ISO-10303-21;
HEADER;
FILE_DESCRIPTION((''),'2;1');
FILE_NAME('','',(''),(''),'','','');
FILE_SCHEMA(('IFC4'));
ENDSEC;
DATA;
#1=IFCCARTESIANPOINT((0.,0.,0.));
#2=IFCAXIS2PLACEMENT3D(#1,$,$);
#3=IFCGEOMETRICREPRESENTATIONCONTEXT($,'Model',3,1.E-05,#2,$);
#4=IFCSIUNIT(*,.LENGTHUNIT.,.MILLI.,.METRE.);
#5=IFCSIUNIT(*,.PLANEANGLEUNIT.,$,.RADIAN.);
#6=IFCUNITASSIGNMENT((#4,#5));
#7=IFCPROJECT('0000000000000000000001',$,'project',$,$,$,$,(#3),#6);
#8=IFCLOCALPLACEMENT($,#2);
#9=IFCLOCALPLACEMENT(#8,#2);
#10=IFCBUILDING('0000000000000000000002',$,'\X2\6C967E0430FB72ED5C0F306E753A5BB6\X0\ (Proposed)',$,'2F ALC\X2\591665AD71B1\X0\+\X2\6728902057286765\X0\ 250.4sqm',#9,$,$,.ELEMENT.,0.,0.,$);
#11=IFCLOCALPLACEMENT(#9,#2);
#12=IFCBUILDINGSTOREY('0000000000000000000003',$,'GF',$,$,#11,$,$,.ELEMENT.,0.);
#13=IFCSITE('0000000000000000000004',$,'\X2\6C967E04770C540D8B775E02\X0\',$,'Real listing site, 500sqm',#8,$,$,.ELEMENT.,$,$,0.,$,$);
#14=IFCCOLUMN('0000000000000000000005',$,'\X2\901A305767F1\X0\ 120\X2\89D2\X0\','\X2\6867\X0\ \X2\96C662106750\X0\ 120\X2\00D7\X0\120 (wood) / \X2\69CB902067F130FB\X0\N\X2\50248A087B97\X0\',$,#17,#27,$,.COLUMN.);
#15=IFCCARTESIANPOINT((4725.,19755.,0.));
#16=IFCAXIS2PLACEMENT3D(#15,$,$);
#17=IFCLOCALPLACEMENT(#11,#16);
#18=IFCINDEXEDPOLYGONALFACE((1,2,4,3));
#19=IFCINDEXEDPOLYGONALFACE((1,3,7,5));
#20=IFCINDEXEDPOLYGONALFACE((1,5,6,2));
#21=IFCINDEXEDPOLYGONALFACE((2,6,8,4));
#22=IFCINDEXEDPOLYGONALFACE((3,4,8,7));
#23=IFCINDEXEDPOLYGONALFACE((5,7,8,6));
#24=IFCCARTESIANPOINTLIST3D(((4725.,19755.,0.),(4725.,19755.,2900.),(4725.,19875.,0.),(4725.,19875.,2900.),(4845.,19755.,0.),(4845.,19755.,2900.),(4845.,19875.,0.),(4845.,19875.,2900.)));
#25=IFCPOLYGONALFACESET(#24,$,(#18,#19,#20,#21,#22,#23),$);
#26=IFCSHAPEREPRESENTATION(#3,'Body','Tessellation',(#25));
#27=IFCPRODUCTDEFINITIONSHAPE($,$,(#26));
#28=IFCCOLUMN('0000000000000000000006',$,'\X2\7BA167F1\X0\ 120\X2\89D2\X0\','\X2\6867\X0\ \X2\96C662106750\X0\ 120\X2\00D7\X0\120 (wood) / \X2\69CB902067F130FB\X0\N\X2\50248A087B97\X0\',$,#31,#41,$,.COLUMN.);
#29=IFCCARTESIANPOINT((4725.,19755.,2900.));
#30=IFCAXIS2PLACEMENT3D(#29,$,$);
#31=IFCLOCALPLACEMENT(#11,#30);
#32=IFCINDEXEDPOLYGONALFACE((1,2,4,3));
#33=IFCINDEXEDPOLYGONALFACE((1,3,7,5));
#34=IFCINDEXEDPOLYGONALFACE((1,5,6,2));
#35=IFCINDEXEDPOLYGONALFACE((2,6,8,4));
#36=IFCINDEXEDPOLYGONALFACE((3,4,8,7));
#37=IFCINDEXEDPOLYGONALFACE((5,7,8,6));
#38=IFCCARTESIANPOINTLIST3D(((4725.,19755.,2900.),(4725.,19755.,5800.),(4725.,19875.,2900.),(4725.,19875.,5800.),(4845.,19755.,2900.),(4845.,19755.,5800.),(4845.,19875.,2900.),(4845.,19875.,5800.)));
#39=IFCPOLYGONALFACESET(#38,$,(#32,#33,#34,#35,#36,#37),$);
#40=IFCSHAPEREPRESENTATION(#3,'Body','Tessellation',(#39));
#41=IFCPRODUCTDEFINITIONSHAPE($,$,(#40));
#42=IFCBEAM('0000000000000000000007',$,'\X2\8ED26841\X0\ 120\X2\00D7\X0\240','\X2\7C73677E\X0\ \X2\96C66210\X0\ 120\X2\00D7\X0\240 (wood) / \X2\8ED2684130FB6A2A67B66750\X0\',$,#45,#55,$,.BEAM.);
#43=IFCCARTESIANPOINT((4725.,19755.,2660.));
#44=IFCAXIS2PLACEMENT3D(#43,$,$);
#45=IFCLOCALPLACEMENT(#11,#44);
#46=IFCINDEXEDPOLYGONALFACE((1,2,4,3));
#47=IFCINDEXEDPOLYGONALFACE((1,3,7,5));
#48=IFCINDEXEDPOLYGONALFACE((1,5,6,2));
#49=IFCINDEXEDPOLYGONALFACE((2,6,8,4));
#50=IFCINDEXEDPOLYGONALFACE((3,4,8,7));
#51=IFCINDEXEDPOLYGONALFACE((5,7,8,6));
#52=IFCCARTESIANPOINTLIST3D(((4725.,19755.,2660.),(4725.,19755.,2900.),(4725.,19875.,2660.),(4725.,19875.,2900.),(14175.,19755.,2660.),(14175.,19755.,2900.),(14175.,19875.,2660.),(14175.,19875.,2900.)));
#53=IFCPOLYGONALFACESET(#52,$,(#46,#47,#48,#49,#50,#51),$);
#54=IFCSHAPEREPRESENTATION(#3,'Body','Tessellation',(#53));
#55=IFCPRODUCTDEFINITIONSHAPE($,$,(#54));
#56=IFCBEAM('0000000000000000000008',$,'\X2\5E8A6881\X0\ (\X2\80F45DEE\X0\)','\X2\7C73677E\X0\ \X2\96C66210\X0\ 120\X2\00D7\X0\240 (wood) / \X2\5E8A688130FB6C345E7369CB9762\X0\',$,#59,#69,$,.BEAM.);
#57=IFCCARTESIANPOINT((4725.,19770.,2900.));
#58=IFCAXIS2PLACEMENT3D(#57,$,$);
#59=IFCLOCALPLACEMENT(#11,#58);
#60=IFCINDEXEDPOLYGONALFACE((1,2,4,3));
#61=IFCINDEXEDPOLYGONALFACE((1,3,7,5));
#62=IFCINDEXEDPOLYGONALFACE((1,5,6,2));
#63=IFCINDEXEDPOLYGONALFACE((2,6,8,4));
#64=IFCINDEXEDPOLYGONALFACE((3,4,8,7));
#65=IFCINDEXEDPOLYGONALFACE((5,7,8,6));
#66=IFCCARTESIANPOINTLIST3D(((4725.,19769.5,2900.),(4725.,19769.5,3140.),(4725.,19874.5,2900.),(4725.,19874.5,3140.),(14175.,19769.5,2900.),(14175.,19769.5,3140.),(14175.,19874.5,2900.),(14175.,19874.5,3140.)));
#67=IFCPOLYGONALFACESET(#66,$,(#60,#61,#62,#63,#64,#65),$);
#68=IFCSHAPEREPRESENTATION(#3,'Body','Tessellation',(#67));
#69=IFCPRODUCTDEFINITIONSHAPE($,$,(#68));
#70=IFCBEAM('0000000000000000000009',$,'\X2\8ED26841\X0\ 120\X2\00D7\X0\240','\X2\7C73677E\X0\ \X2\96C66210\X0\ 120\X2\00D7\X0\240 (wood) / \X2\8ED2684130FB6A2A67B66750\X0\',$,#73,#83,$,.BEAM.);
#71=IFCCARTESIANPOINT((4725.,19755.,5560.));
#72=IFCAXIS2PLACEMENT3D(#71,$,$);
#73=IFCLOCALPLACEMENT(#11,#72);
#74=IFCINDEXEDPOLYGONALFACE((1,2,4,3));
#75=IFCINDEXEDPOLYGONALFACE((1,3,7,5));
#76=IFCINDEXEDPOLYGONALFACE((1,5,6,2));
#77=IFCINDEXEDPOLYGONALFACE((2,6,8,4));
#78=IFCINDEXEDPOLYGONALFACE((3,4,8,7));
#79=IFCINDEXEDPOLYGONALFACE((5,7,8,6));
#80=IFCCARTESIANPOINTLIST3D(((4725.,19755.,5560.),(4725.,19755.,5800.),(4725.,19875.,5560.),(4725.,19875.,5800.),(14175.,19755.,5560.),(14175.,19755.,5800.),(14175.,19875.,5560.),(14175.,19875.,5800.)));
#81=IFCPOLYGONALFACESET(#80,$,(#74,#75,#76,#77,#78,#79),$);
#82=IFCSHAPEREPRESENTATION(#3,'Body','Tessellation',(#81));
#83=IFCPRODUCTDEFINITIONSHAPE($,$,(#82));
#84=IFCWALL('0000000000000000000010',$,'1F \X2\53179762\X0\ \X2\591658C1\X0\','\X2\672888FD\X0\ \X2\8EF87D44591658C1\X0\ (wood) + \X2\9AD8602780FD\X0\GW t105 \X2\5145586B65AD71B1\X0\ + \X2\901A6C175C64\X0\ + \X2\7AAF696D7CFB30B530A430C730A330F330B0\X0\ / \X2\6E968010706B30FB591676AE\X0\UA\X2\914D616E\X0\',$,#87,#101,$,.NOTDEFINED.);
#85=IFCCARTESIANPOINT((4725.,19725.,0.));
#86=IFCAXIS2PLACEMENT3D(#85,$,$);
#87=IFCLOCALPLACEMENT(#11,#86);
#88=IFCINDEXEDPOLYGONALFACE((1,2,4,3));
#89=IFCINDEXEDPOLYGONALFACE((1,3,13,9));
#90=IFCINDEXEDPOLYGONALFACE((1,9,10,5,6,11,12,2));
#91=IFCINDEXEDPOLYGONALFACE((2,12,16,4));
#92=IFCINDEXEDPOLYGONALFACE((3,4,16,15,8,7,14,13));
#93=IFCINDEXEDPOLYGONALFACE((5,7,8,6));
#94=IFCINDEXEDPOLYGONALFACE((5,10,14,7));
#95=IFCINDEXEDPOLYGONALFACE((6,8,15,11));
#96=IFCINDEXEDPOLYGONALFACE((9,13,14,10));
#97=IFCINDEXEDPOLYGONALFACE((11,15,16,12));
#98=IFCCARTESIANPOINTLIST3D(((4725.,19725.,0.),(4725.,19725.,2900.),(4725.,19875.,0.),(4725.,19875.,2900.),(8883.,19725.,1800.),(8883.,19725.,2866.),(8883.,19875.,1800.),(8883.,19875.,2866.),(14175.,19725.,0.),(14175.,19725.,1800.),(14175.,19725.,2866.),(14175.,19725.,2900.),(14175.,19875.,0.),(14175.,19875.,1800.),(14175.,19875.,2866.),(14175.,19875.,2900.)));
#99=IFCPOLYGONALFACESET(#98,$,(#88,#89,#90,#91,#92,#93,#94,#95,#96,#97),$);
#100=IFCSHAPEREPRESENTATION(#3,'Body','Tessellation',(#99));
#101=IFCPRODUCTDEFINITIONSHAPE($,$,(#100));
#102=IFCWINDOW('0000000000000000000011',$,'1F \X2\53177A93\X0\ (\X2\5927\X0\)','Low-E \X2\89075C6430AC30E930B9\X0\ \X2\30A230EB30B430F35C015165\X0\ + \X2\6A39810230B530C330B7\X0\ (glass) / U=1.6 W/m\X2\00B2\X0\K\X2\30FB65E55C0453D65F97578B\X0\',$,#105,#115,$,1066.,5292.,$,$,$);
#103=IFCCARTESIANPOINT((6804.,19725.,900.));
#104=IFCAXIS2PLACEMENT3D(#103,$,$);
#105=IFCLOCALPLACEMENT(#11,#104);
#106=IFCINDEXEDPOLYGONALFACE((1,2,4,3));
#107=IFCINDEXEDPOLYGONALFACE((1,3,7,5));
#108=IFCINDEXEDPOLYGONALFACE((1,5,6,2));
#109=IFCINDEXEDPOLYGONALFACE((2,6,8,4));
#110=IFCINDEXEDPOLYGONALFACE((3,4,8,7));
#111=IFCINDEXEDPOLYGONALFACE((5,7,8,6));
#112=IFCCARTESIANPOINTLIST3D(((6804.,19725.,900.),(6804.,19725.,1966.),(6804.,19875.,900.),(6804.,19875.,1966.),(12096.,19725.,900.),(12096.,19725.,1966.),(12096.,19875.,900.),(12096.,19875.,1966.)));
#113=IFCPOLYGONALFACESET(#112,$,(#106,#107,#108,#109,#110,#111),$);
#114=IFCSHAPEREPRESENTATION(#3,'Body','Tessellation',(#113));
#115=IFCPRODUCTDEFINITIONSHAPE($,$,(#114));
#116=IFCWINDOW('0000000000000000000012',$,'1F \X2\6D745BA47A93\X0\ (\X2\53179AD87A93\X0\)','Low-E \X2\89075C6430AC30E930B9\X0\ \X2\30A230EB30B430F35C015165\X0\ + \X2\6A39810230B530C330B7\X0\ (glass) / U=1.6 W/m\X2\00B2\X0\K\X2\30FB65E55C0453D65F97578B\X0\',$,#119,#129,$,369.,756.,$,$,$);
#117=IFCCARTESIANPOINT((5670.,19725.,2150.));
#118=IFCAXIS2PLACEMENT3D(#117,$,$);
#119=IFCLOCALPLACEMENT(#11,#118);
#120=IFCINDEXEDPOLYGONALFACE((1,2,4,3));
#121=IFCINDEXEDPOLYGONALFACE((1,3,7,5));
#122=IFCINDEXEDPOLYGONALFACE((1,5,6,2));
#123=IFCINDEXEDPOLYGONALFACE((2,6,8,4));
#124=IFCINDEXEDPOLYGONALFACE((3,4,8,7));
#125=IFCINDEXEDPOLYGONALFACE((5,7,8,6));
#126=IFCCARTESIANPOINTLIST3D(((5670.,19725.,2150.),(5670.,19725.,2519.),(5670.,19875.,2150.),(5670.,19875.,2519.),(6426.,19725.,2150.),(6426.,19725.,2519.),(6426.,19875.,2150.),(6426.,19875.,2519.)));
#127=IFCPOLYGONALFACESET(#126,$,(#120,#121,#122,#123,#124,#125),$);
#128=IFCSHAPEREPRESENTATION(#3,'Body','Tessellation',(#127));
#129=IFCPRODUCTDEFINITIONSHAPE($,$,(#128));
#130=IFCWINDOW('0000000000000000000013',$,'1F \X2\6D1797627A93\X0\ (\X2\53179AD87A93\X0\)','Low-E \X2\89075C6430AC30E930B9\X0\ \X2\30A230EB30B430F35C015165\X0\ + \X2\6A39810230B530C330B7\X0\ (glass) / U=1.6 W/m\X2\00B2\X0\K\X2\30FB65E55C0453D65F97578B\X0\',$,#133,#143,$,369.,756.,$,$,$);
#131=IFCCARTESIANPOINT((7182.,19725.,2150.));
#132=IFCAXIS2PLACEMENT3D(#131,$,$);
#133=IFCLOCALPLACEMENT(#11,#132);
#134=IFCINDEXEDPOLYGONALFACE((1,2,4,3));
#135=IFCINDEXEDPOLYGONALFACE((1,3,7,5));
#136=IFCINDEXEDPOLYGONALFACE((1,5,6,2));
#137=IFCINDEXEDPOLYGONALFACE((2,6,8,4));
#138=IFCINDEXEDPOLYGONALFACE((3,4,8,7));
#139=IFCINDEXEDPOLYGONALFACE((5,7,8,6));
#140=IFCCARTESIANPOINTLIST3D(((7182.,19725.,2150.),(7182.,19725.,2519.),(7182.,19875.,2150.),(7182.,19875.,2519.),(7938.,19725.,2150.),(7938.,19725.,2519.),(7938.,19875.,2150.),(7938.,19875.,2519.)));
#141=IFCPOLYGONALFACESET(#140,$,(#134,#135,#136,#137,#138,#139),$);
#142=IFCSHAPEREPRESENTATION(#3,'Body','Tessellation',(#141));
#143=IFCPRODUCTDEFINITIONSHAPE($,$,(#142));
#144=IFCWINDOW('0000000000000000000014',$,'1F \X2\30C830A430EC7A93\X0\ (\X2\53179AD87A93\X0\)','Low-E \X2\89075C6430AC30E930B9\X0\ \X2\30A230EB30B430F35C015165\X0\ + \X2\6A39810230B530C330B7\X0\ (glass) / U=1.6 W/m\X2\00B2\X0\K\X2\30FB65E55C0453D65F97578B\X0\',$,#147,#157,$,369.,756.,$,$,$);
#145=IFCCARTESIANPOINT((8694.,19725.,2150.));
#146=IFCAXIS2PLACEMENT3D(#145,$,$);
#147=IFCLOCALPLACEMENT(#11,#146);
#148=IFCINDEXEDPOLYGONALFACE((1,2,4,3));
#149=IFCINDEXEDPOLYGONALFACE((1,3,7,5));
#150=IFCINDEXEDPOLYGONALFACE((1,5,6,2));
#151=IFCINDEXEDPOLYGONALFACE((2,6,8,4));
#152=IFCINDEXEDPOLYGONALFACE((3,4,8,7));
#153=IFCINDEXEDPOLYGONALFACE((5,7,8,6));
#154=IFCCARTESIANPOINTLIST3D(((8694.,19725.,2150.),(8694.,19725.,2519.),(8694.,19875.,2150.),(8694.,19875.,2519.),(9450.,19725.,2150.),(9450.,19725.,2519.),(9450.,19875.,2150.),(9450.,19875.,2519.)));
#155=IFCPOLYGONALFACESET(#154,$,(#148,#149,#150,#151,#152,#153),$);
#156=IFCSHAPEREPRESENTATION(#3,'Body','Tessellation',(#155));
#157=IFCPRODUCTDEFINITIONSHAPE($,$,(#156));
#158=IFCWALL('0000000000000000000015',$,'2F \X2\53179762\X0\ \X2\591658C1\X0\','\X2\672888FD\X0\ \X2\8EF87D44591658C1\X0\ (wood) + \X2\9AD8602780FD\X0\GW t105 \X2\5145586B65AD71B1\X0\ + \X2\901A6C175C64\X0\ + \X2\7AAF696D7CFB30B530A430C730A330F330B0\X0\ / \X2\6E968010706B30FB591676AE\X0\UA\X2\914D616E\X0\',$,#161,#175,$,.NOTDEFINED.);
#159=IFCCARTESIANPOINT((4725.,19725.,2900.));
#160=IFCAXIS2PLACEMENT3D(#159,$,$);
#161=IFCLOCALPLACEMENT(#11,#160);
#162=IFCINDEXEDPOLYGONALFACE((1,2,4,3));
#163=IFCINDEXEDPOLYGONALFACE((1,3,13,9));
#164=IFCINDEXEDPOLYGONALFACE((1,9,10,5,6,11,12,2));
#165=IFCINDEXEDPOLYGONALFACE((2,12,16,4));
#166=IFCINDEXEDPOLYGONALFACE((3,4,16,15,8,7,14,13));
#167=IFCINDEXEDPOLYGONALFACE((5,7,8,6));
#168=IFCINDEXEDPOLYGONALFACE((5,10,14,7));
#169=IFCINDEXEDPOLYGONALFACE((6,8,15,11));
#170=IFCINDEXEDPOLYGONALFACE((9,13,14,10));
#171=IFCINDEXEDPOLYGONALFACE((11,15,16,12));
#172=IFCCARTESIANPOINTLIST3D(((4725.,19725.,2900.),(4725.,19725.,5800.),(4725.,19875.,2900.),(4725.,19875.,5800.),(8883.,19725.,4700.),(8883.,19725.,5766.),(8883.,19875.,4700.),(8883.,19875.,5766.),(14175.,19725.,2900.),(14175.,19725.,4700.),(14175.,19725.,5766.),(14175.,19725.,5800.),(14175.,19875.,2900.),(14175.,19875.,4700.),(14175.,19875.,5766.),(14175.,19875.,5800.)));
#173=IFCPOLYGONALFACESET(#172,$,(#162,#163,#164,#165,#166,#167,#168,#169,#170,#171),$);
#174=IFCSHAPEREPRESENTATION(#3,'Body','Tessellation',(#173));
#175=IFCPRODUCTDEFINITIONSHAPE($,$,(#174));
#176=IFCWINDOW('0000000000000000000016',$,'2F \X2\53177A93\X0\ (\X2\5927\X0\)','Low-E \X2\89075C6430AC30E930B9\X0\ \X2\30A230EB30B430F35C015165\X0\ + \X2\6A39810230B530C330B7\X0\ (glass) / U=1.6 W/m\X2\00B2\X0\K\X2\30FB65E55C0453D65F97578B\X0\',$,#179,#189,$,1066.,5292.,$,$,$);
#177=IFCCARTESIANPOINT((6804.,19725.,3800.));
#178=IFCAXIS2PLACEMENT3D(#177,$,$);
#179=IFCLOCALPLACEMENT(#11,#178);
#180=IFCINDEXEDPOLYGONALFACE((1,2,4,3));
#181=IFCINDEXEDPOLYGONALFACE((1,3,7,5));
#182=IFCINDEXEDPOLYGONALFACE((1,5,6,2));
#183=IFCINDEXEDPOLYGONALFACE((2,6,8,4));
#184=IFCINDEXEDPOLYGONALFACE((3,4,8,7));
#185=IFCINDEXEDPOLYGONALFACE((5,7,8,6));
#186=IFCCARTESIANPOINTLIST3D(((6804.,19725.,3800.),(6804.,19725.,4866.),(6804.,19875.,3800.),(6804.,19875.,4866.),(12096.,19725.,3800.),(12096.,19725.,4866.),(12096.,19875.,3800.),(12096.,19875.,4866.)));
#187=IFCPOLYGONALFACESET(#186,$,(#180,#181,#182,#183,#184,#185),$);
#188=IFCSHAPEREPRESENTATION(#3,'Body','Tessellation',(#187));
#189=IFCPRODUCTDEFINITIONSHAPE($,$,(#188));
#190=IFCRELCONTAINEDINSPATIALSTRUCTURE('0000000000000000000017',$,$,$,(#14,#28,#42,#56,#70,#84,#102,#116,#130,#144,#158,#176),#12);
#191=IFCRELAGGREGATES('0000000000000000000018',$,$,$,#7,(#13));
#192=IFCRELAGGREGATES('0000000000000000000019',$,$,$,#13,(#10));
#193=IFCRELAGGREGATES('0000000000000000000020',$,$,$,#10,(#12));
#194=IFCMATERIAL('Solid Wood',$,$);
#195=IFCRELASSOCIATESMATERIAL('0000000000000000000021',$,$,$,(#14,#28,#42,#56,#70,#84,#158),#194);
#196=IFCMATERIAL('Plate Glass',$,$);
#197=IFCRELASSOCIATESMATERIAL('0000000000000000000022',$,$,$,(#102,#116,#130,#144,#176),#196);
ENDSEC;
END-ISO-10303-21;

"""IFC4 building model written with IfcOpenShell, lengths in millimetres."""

from ifc_helpers import new_model, si_unit, frame, frame_2d, origin, place, context, project, spatial, rectangle, extrude, material, element, fill, save


model = new_model("IFC4")

# Units and contexts
model_context = context("Model", 3, precision=1e-05, world=origin())
ifc_project = project(units=[si_unit("LENGTHUNIT", "METRE", prefix="MILLI"), si_unit("PLANEANGLEUNIT", "RADIAN")], contexts=[model_context])

# Site, building, storey
site_placement = place(None, origin())
site = spatial("IfcSite", under=ifc_project, at=site_placement, Name="沖縄県名護市", ObjectType="Real listing site, 500sqm", CompositionType="ELEMENT", RefElevation=0.0)
building_placement = place(site_placement, origin())
building = spatial("IfcBuilding", under=site, at=building_placement, Name="沖縄・狭小の町家 (Proposed)", ObjectType="2F ALC外断熱+木造在来 250.4sqm", CompositionType="ELEMENT", ElevationOfRefHeight=0.0, ElevationOfTerrain=0.0)
storey_placement = place(building_placement, origin())
storey = spatial("IfcBuildingStorey", under=building, at=storey_placement, Name="GF", CompositionType="ELEMENT", Elevation=0.0)

# Columns
ifc_material_1 = material(Name="Solid Wood")
column_1_placement = place(storey_placement, frame((4725.0, 19755.0, 0.0)))
element("IfcColumn", 1, at=column_1_placement, inside=storey, material=ifc_material_1, Name="通し柱 120角", Description="桧 集成材 120×120 (wood) / 構造柱・N値計算", PredefinedType="COLUMN", context=model_context, shape_type="SweptSolid", body=[
    extrude(rectangle(XDim=120.0, YDim=120.0, at=frame_2d((60.0, 60.0))), frame((4725.0, 19755.0, 0.0)), (0.0, 0.0, 1.0), 2900.0),
])
column_2_placement = place(storey_placement, frame((4725.0, 19755.0, 2900.0)))
element("IfcColumn", 2, at=column_2_placement, inside=storey, material=ifc_material_1, Name="管柱 120角", Description="桧 集成材 120×120 (wood) / 構造柱・N値計算", PredefinedType="COLUMN", context=model_context, shape_type="SweptSolid", body=[
    extrude(rectangle(XDim=120.0, YDim=120.0, at=frame_2d((60.0, 60.0))), frame((4725.0, 19755.0, 2900.0)), (0.0, 0.0, 1.0), 2900.0),
])

# Beams
beam_1_placement = place(storey_placement, frame((4725.0, 19755.0, 2660.0)))
element("IfcBeam", 3, at=beam_1_placement, inside=storey, material=ifc_material_1, Name="軒桁 120×240", Description="米松 集成 120×240 (wood) / 軒桁・横架材", PredefinedType="BEAM", context=model_context, shape_type="SweptSolid", body=[
    extrude(rectangle(XDim=9450.0, YDim=120.0, at=frame_2d((4725.0, 60.0))), frame((4725.0, 19755.0, 2660.0)), (0.0, 0.0, 1.0), 240.0),
])
beam_2_placement = place(storey_placement, frame((4725.0, 19770.0, 2900.0)))
element("IfcBeam", 4, at=beam_2_placement, inside=storey, material=ifc_material_1, Name="床梁 (胴差)", Description="米松 集成 120×240 (wood) / 床梁・水平構面", PredefinedType="BEAM", context=model_context, shape_type="SweptSolid", body=[
    extrude(rectangle(XDim=9450.0, YDim=105.0, at=frame_2d((4725.0, 52.0))), frame((4725.0, 19770.0, 2900.0)), (0.0, 0.0, 1.0), 240.0),
])
beam_3_placement = place(storey_placement, frame((4725.0, 19755.0, 5560.0)))
element("IfcBeam", 5, at=beam_3_placement, inside=storey, material=ifc_material_1, Name="軒桁 120×240", Description="米松 集成 120×240 (wood) / 軒桁・横架材", PredefinedType="BEAM", context=model_context, shape_type="SweptSolid", body=[
    extrude(rectangle(XDim=9450.0, YDim=120.0, at=frame_2d((4725.0, 60.0))), frame((4725.0, 19755.0, 5560.0)), (0.0, 0.0, 1.0), 240.0),
])

# Wall, openings, windows
wall_1_placement = place(storey_placement, frame((4725.0, 19725.0, 0.0)))
wall_1 = element("IfcWall", 6, at=wall_1_placement, inside=storey, material=ifc_material_1, Name="1F 北面 外壁", Description="木製 軸組外壁 (wood) + 高性能GW t105 充填断熱 + 通気層 + 窯業系サイディング / 準耐火・外皮UA配慮", PredefinedType="NOTDEFINED", context=model_context, shape_type="SweptSolid", body=[
    extrude(rectangle(XDim=9450.0, YDim=150.0, at=frame_2d((4725.0, 75.0))), frame((4725.0, 19725.0, 0.0)), (0.0, 0.0, 1.0), 2900.0),
])
opening_1_placement = place(storey_placement, frame((6804.0, 19725.0, 900.0)))
opening_1 = element("IfcOpeningElement", 7, at=opening_1_placement, cuts=wall_1, PredefinedType="NOTDEFINED", context=model_context, shape_type="SweptSolid", body=[
    extrude(rectangle(XDim=5292.0, YDim=150.0, at=frame_2d((2646.0, 75.0))), frame((6804.0, 19725.0, 900.0)), (0.0, 0.0, 1.0), 1066.0),
])
opening_2_placement = place(storey_placement, frame((5670.0, 19725.0, 2150.0)))
opening_2 = element("IfcOpeningElement", 8, at=opening_2_placement, cuts=wall_1, PredefinedType="NOTDEFINED", context=model_context, shape_type="SweptSolid", body=[
    extrude(rectangle(XDim=756.0, YDim=150.0, at=frame_2d((378.0, 75.0))), frame((5670.0, 19725.0, 2150.0)), (0.0, 0.0, 1.0), 369.0),
])
opening_3_placement = place(storey_placement, frame((7182.0, 19725.0, 2150.0)))
opening_3 = element("IfcOpeningElement", 9, at=opening_3_placement, cuts=wall_1, PredefinedType="NOTDEFINED", context=model_context, shape_type="SweptSolid", body=[
    extrude(rectangle(XDim=756.0, YDim=150.0, at=frame_2d((378.0, 75.0))), frame((7182.0, 19725.0, 2150.0)), (0.0, 0.0, 1.0), 369.0),
])
opening_4_placement = place(storey_placement, frame((8694.0, 19725.0, 2150.0)))
opening_4 = element("IfcOpeningElement", 10, at=opening_4_placement, cuts=wall_1, PredefinedType="NOTDEFINED", context=model_context, shape_type="SweptSolid", body=[
    extrude(rectangle(XDim=756.0, YDim=150.0, at=frame_2d((378.0, 75.0))), frame((8694.0, 19725.0, 2150.0)), (0.0, 0.0, 1.0), 369.0),
])
ifc_material_2 = material(Name="Plate Glass")
window_1_placement = place(storey_placement, frame((6804.0, 19725.0, 900.0)))
window_1 = element("IfcWindow", 11, at=window_1_placement, inside=storey, material=ifc_material_2, Name="1F 北窓 (大)", Description="Low-E 複層ガラス アルゴン封入 + 樹脂サッシ (glass) / U=1.6 W/m²K・日射取得型", OverallHeight=1066.0, OverallWidth=5292.0, context=model_context, shape_type="SweptSolid", body=[
    extrude(rectangle(XDim=5292.0, YDim=150.0, at=frame_2d((2646.0, 75.0))), frame((6804.0, 19725.0, 900.0)), (0.0, 0.0, 1.0), 1066.0),
])
fill(opening_1, window_1)
window_2_placement = place(storey_placement, frame((5670.0, 19725.0, 2150.0)))
window_2 = element("IfcWindow", 12, at=window_2_placement, inside=storey, material=ifc_material_2, Name="1F 浴室窓 (北高窓)", Description="Low-E 複層ガラス アルゴン封入 + 樹脂サッシ (glass) / U=1.6 W/m²K・日射取得型", OverallHeight=369.0, OverallWidth=756.0, context=model_context, shape_type="SweptSolid", body=[
    extrude(rectangle(XDim=756.0, YDim=150.0, at=frame_2d((378.0, 75.0))), frame((5670.0, 19725.0, 2150.0)), (0.0, 0.0, 1.0), 369.0),
])
fill(opening_2, window_2)
window_3_placement = place(storey_placement, frame((7182.0, 19725.0, 2150.0)))
window_3 = element("IfcWindow", 13, at=window_3_placement, inside=storey, material=ifc_material_2, Name="1F 洗面窓 (北高窓)", Description="Low-E 複層ガラス アルゴン封入 + 樹脂サッシ (glass) / U=1.6 W/m²K・日射取得型", OverallHeight=369.0, OverallWidth=756.0, context=model_context, shape_type="SweptSolid", body=[
    extrude(rectangle(XDim=756.0, YDim=150.0, at=frame_2d((378.0, 75.0))), frame((7182.0, 19725.0, 2150.0)), (0.0, 0.0, 1.0), 369.0),
])
fill(opening_3, window_3)
window_4_placement = place(storey_placement, frame((8694.0, 19725.0, 2150.0)))
window_4 = element("IfcWindow", 14, at=window_4_placement, inside=storey, material=ifc_material_2, Name="1F トイレ窓 (北高窓)", Description="Low-E 複層ガラス アルゴン封入 + 樹脂サッシ (glass) / U=1.6 W/m²K・日射取得型", OverallHeight=369.0, OverallWidth=756.0, context=model_context, shape_type="SweptSolid", body=[
    extrude(rectangle(XDim=756.0, YDim=150.0, at=frame_2d((378.0, 75.0))), frame((8694.0, 19725.0, 2150.0)), (0.0, 0.0, 1.0), 369.0),
])
fill(opening_4, window_4)

# Wall, opening, window
wall_2_placement = place(storey_placement, frame((4725.0, 19725.0, 2900.0)))
wall_2 = element("IfcWall", 15, at=wall_2_placement, inside=storey, material=ifc_material_1, Name="2F 北面 外壁", Description="木製 軸組外壁 (wood) + 高性能GW t105 充填断熱 + 通気層 + 窯業系サイディング / 準耐火・外皮UA配慮", PredefinedType="NOTDEFINED", context=model_context, shape_type="SweptSolid", body=[
    extrude(rectangle(XDim=9450.0, YDim=150.0, at=frame_2d((4725.0, 75.0))), frame((4725.0, 19725.0, 2900.0)), (0.0, 0.0, 1.0), 2900.0),
])
opening_5_placement = place(storey_placement, frame((6804.0, 19725.0, 3800.0)))
opening_5 = element("IfcOpeningElement", 16, at=opening_5_placement, cuts=wall_2, PredefinedType="NOTDEFINED", context=model_context, shape_type="SweptSolid", body=[
    extrude(rectangle(XDim=5292.0, YDim=150.0, at=frame_2d((2646.0, 75.0))), frame((6804.0, 19725.0, 3800.0)), (0.0, 0.0, 1.0), 1066.0),
])
window_5_placement = place(storey_placement, frame((6804.0, 19725.0, 3800.0)))
window_5 = element("IfcWindow", 17, at=window_5_placement, inside=storey, material=ifc_material_2, Name="2F 北窓 (大)", Description="Low-E 複層ガラス アルゴン封入 + 樹脂サッシ (glass) / U=1.6 W/m²K・日射取得型", OverallHeight=1066.0, OverallWidth=5292.0, context=model_context, shape_type="SweptSolid", body=[
    extrude(rectangle(XDim=5292.0, YDim=150.0, at=frame_2d((2646.0, 75.0))), frame((6804.0, 19725.0, 3800.0)), (0.0, 0.0, 1.0), 1066.0),
])
fill(opening_5, window_5)

save(model, "model.ifc")
